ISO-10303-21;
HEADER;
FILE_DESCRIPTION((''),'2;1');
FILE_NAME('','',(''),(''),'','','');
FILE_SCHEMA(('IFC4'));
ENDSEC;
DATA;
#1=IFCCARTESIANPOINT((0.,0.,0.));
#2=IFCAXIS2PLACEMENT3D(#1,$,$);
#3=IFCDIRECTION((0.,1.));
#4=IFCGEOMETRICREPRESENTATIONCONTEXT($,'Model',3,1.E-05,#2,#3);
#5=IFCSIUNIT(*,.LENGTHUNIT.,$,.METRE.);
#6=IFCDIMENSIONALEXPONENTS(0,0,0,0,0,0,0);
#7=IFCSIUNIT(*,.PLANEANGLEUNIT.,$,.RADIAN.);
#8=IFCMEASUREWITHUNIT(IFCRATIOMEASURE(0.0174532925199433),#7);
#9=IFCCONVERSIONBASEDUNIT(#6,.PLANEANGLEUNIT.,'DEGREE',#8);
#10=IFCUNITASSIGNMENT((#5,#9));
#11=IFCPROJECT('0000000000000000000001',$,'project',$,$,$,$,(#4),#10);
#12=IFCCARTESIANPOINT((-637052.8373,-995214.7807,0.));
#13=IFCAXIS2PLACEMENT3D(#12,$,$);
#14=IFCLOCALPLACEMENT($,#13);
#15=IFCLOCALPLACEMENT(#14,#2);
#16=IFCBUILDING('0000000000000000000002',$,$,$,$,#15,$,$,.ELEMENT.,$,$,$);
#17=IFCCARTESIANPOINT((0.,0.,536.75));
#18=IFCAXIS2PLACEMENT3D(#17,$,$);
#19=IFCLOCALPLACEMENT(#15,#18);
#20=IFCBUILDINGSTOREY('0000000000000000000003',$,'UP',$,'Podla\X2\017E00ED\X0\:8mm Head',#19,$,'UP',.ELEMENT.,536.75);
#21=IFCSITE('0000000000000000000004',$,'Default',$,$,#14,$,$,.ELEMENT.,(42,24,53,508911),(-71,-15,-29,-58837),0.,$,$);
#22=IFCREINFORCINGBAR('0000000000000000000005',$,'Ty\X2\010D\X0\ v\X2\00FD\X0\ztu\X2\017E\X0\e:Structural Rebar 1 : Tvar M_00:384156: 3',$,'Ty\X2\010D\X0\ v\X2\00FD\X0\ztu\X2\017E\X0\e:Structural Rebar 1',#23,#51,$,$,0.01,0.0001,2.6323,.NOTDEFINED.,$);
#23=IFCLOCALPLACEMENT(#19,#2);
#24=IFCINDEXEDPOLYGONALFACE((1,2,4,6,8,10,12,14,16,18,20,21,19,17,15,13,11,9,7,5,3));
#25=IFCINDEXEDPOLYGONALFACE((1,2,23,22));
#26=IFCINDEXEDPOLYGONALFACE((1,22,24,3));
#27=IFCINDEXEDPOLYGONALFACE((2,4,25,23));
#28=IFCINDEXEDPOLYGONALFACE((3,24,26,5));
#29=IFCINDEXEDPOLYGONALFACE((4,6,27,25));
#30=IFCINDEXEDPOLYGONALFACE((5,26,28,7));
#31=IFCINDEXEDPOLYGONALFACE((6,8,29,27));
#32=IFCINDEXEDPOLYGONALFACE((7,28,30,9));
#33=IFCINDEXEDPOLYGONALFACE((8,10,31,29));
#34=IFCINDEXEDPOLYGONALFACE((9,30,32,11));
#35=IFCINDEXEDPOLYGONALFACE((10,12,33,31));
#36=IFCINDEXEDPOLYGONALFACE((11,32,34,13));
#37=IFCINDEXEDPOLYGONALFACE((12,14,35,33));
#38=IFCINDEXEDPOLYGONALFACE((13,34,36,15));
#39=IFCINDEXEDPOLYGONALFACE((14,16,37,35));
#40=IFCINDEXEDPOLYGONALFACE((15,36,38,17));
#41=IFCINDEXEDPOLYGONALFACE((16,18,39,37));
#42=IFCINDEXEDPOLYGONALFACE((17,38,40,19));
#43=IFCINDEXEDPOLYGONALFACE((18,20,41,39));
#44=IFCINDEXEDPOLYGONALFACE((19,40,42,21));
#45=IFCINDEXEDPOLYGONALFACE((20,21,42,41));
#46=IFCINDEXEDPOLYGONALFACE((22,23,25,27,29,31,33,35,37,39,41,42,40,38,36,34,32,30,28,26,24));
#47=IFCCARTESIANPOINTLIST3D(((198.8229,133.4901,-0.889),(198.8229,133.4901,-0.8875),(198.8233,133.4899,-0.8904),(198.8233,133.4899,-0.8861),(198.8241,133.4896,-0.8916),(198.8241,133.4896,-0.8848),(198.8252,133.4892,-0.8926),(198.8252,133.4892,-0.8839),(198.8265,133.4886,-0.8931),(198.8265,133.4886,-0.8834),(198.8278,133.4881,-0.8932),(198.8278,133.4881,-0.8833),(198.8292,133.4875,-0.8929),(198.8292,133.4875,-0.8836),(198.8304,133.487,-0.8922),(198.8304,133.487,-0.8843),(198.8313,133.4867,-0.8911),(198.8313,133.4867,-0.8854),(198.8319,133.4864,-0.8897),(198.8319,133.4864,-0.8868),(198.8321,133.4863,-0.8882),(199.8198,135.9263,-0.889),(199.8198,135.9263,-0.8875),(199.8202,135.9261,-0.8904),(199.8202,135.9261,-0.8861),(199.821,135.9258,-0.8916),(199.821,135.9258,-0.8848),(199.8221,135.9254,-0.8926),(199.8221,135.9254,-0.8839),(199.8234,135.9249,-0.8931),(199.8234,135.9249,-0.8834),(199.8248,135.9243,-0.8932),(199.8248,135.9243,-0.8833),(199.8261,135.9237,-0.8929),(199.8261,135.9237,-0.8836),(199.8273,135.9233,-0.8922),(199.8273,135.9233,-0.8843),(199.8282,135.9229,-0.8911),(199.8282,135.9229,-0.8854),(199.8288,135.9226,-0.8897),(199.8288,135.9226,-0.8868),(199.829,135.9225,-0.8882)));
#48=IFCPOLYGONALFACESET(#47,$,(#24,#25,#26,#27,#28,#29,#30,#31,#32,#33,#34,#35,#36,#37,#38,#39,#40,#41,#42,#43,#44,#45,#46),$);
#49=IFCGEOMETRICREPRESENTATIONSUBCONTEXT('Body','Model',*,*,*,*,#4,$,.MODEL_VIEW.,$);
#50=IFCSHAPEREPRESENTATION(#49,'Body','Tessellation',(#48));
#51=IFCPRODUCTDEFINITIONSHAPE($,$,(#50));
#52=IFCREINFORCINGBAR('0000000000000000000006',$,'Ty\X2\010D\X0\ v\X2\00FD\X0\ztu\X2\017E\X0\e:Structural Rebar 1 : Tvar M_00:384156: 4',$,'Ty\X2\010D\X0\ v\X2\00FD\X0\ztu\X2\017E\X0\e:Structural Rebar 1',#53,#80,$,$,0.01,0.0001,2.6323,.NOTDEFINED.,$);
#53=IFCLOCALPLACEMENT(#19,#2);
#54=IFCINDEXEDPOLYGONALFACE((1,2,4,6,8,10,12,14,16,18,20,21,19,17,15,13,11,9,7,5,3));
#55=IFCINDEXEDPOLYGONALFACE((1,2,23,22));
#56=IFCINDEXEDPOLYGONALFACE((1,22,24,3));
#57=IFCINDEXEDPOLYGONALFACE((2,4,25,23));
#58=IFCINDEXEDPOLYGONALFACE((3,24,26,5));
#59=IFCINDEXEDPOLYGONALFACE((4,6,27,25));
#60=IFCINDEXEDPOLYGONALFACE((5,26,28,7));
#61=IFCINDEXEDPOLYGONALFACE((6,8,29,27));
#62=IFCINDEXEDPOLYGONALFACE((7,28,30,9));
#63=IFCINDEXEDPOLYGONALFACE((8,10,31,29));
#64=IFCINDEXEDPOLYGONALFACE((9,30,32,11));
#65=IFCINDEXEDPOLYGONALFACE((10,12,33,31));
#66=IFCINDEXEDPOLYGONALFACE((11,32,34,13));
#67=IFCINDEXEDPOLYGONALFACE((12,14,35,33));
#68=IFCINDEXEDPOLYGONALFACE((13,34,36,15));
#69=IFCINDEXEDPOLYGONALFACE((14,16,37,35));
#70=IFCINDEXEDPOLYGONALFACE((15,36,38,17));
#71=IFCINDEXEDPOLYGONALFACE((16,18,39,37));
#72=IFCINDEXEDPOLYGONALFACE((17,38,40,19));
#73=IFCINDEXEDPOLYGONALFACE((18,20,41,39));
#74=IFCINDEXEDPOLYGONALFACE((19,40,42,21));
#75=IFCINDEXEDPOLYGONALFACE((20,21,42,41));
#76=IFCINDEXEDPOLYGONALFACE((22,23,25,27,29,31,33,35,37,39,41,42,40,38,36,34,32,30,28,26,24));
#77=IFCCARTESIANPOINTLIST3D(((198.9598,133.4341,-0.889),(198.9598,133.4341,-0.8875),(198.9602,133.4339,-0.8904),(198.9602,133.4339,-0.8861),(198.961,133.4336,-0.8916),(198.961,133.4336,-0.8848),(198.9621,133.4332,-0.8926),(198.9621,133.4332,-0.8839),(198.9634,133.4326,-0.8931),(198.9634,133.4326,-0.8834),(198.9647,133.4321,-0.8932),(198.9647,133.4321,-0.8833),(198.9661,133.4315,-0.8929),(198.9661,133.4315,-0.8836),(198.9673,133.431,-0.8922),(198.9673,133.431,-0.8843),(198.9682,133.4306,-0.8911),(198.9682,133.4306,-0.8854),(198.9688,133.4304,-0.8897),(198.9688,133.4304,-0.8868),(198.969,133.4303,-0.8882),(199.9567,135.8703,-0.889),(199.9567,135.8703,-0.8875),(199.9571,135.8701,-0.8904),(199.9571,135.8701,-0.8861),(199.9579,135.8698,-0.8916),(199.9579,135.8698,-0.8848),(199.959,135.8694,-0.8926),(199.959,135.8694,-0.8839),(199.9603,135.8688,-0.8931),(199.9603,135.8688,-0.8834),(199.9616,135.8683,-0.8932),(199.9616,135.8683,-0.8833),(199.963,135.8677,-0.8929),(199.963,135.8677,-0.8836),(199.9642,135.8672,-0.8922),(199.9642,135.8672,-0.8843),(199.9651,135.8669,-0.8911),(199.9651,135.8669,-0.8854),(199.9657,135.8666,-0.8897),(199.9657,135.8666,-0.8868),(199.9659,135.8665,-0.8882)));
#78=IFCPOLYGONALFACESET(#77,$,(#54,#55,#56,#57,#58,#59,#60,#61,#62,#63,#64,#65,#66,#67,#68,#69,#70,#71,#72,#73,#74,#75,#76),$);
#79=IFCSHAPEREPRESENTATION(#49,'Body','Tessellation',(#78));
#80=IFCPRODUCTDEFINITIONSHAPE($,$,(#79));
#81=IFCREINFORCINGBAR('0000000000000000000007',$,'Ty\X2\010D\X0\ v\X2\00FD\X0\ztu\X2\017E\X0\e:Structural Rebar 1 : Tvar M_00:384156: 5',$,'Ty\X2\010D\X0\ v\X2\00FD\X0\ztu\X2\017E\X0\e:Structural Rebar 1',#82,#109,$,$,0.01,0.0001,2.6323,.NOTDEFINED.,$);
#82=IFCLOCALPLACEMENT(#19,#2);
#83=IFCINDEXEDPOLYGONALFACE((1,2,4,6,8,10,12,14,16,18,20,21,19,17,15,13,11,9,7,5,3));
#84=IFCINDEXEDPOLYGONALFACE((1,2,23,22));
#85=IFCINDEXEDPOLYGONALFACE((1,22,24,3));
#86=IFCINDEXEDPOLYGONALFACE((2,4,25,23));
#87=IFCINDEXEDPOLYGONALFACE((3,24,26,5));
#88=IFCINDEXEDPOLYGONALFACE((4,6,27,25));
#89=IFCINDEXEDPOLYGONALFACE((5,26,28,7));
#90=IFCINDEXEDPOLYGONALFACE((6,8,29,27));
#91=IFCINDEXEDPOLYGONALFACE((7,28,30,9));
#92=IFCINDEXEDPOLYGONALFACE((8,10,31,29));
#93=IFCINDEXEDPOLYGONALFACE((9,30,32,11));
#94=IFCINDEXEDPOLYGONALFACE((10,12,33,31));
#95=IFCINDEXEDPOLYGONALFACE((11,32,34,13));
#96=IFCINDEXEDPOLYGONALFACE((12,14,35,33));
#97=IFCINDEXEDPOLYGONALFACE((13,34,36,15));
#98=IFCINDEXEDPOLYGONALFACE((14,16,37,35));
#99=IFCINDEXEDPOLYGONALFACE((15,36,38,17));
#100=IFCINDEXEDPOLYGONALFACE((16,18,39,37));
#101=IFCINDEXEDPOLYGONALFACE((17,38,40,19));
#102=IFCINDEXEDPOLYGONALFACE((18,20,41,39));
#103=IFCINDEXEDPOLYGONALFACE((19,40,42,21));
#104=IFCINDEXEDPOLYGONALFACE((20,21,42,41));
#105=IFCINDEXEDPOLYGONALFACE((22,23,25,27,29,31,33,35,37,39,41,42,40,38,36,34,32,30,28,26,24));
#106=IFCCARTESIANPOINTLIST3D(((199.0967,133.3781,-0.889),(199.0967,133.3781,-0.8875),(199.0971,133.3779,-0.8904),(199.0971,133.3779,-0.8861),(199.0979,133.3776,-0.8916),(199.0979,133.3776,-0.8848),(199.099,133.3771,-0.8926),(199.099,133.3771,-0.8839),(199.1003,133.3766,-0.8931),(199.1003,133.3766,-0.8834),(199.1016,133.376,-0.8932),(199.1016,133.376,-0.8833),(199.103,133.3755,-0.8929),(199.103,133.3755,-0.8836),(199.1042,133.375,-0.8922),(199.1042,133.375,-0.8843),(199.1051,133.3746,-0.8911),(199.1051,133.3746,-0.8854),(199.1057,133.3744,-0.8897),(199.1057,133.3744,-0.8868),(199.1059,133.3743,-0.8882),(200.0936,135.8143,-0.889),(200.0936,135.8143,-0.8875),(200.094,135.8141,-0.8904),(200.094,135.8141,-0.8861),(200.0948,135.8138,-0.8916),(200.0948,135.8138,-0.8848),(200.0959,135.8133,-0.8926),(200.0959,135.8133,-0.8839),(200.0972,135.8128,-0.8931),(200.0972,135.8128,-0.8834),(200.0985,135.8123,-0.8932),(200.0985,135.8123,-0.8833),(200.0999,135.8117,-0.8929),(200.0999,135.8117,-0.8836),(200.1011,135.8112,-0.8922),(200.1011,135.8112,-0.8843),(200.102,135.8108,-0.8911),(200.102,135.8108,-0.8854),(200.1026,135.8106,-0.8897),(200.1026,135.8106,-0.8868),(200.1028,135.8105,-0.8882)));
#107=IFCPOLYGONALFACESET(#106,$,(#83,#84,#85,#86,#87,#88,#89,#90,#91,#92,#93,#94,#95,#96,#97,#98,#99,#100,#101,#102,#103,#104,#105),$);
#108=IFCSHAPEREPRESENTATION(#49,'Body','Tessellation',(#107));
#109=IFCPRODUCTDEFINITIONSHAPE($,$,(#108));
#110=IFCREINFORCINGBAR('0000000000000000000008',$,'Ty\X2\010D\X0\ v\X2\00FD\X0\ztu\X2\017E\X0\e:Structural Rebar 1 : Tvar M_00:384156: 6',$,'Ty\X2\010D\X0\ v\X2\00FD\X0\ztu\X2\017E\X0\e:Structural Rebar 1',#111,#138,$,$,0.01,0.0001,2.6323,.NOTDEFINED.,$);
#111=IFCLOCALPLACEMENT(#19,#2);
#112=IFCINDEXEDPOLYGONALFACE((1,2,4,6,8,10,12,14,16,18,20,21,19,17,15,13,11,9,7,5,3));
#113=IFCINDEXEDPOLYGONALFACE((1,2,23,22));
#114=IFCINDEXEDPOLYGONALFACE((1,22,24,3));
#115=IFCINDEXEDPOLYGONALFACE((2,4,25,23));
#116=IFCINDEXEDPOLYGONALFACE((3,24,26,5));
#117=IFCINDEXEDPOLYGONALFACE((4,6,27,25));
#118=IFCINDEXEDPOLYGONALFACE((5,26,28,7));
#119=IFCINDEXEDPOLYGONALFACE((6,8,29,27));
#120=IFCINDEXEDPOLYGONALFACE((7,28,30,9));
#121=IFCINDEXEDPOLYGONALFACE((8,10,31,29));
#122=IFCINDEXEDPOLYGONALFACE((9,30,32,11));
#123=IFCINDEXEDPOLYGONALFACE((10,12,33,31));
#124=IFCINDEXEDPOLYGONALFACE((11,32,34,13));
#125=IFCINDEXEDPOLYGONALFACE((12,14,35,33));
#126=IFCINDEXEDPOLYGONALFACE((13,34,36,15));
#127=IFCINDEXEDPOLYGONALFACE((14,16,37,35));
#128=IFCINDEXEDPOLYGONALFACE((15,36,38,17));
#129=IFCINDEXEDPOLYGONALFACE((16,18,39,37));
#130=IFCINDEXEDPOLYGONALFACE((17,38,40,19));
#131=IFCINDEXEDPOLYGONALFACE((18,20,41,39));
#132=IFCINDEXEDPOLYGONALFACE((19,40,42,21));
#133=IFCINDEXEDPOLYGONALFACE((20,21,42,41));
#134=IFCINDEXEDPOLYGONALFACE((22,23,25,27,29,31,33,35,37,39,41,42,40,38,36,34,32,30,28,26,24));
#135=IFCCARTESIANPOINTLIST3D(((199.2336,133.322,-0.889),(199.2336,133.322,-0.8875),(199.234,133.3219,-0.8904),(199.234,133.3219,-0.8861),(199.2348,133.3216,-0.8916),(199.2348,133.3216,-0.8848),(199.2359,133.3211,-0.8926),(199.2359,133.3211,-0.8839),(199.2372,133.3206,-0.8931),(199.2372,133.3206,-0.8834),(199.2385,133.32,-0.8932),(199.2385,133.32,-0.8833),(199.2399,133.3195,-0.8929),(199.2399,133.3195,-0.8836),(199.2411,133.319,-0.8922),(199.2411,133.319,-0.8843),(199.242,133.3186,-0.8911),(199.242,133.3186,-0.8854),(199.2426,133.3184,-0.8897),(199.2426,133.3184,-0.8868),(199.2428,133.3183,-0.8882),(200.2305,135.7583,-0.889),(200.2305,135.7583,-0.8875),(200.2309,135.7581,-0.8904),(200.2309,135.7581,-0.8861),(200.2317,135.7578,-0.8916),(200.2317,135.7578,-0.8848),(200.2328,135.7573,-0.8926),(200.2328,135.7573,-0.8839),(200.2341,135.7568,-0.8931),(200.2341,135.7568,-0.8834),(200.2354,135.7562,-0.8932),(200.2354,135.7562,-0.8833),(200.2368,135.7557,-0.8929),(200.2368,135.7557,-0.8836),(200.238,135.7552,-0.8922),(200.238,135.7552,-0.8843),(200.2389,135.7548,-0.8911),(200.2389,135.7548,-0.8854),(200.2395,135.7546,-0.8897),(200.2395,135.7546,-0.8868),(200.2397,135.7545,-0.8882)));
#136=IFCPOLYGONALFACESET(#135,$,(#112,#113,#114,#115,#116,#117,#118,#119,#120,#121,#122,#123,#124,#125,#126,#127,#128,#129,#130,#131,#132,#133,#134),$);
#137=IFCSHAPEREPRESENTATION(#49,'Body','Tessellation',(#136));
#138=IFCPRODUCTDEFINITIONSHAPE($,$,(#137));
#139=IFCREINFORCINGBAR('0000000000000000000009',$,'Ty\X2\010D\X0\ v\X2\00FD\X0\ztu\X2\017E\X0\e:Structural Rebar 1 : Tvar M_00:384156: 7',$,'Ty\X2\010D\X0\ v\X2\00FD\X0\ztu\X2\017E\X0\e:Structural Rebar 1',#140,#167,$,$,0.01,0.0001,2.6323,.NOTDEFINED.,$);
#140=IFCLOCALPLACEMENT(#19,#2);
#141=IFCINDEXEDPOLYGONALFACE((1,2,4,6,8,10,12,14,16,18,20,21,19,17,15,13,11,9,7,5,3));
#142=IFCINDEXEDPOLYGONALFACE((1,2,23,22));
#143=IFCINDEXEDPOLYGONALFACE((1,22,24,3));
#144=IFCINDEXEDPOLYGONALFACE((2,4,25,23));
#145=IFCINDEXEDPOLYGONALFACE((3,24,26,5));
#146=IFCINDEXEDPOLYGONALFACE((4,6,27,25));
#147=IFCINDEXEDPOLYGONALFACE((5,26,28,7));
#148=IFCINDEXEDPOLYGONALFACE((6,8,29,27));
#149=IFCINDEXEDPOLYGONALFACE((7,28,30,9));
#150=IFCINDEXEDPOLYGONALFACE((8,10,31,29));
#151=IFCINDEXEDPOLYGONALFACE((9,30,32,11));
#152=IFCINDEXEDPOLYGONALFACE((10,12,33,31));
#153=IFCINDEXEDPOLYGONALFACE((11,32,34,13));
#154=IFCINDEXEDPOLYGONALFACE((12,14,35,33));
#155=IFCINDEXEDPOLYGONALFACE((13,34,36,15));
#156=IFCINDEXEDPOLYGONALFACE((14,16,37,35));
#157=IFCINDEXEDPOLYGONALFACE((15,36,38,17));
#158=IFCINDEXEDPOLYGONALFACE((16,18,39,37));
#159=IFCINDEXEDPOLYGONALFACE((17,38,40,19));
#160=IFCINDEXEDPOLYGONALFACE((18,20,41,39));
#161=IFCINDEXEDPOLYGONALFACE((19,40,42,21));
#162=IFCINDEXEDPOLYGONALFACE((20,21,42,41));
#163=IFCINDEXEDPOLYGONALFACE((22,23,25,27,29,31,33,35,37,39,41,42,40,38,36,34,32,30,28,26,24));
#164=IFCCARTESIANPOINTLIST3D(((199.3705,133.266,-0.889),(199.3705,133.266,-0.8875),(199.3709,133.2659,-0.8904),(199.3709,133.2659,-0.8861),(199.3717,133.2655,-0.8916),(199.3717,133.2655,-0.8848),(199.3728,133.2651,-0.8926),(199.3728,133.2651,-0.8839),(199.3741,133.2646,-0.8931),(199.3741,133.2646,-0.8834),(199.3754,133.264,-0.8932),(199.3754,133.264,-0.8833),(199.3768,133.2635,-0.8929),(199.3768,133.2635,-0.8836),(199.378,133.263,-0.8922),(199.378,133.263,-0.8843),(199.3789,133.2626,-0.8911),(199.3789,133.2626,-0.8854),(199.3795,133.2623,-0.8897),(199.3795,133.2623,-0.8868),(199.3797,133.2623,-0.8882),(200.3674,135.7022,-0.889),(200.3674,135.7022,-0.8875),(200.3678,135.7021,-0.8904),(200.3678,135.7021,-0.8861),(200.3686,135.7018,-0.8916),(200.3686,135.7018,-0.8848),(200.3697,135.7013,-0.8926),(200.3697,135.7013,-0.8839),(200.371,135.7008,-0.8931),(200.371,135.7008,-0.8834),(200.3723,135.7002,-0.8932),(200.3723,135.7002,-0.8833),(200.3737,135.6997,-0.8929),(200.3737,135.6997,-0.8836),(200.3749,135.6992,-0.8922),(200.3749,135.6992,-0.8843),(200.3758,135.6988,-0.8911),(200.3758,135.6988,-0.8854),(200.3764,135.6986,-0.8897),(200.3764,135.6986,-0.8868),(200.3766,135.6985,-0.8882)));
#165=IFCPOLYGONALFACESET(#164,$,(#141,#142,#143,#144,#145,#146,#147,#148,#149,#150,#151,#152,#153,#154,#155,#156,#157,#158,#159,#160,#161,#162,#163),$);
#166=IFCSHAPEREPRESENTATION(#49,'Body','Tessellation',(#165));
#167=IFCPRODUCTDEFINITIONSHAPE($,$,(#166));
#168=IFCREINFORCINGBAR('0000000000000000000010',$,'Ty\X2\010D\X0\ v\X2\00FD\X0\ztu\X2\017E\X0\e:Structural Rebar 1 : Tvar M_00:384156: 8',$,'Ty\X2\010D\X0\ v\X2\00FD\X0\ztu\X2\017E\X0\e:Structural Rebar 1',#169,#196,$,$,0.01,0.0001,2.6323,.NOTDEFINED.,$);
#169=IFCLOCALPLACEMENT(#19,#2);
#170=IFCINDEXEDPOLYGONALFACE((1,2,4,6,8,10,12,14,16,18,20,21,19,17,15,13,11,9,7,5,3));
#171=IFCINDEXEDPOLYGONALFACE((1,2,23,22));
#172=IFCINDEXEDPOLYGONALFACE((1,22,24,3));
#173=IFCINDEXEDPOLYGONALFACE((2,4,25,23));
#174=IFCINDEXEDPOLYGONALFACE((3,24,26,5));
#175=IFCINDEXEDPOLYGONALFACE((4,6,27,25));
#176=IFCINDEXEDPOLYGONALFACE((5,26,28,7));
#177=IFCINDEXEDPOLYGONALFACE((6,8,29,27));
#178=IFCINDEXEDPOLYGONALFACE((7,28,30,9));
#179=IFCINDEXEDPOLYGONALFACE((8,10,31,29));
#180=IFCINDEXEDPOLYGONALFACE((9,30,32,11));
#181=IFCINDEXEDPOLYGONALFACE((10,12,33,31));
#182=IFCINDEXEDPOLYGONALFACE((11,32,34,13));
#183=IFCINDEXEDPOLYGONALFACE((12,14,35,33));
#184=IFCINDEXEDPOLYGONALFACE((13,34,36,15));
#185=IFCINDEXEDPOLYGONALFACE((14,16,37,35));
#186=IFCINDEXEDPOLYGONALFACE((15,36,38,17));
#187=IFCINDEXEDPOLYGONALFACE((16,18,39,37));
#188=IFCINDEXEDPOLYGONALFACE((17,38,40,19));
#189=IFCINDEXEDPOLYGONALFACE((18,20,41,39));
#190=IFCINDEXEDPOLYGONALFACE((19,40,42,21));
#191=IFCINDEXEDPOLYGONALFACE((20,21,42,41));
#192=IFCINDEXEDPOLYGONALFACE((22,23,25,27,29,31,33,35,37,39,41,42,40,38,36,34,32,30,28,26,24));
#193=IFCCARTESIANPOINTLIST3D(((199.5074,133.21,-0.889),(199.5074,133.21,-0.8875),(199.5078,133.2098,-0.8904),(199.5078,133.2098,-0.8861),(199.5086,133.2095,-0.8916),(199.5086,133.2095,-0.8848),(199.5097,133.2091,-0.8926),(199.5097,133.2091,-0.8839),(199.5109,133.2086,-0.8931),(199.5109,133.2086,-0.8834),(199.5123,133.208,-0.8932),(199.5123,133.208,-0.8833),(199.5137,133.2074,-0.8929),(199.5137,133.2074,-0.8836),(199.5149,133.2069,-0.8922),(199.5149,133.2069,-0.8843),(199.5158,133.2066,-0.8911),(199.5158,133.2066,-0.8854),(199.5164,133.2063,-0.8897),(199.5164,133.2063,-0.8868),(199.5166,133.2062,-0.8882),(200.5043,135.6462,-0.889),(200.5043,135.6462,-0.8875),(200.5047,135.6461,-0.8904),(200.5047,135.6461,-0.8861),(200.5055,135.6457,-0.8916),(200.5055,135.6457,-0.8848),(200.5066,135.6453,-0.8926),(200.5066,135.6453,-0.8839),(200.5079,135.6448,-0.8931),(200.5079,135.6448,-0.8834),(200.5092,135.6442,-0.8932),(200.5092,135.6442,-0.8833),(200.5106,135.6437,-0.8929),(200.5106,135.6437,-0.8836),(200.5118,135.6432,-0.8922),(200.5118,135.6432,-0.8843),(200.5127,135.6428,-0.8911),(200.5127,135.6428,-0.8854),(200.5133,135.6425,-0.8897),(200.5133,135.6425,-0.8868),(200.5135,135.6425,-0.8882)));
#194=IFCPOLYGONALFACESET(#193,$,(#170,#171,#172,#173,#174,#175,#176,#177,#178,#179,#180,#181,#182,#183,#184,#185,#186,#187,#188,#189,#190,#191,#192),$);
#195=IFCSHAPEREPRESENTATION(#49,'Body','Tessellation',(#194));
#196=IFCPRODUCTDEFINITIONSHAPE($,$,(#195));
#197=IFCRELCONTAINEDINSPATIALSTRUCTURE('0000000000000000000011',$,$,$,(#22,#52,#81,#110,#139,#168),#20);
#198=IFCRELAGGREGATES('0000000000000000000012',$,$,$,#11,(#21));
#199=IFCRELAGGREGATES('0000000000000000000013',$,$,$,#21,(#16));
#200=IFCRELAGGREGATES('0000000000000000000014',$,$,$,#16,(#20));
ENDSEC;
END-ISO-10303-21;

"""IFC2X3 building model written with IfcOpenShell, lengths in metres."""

from ifc_helpers import new_model, entity, si_unit, converted_unit, direction, frame, origin, place, context, subcontext, project, spatial, element, save


model = new_model("IFC2X3")

# Units and contexts
model_context = context("Model", 3, precision=1e-05, world=origin(), true_north=direction((0.0, 1.0)))
body_context = subcontext(model_context, "Body", "Model", "MODEL_VIEW")
ifc_project = project(units=[si_unit("LENGTHUNIT", "METRE"), converted_unit("PLANEANGLEUNIT", "DEGREE", entity("IfcRatioMeasure", 0.0174532925199433), si_unit("PLANEANGLEUNIT", "RADIAN"), dimensions=[0, 0, 0, 0, 0, 0, 0])], contexts=[model_context])

# Site, building, storey
site_placement = place(None, frame((-637052.8373, -995214.7807, 0.0)))
site = spatial("IfcSite", under=ifc_project, at=site_placement, Name="Default", CompositionType="ELEMENT", RefLatitude=(42, 24, 53, 508911), RefLongitude=(-71, -15, -29, -58837), RefElevation=0.0)
building_placement = place(site_placement, origin())
building = spatial("IfcBuilding", under=site, at=building_placement, CompositionType="ELEMENT")
storey_placement = place(building_placement, frame((0.0, 0.0, 536.75)))
storey = spatial("IfcBuildingStorey", under=building, at=storey_placement, Name="UP", ObjectType="Podlaží:8mm Head", LongName="UP", CompositionType="ELEMENT", Elevation=536.75)

# Reinforcing bars
reinforcing_bar_1_placement = place(storey_placement, origin())
element("IfcReinforcingBar", 1, at=reinforcing_bar_1_placement, inside=storey, Name="Tyč výztuže:Structural Rebar 1 : Tvar M_00:384156: 3", ObjectType="Tyč výztuže:Structural Rebar 1", BarLength=2.6323, BarRole="NOTDEFINED", CrossSectionArea=0.0001, NominalDiameter=0.01, context=body_context, shape_type="AdvancedSweptSolid", body=[
    entity("IfcSweptDiskSolid", entity("IfcCompositeCurve", [entity("IfcCompositeCurveSegment", "CONTINUOUS", True, entity("IfcPolyline", [entity("IfcCartesianPoint", [-199.8244, -135.9244, 0.8882]), entity("IfcCartesianPoint", [-198.8275, -133.4882, 0.8882])]))], False), 0.005, None, 0.0, 1.0),
])
reinforcing_bar_2_placement = place(storey_placement, origin())
element("IfcReinforcingBar", 2, at=reinforcing_bar_2_placement, inside=storey, Name="Tyč výztuže:Structural Rebar 1 : Tvar M_00:384156: 4", ObjectType="Tyč výztuže:Structural Rebar 1", BarLength=2.6323, BarRole="NOTDEFINED", CrossSectionArea=0.0001, NominalDiameter=0.01, context=body_context, shape_type="AdvancedSweptSolid", body=[
    entity("IfcSweptDiskSolid", entity("IfcCompositeCurve", [entity("IfcCompositeCurveSegment", "CONTINUOUS", True, entity("IfcPolyline", [entity("IfcCartesianPoint", [-199.9613, -135.8684, 0.8882]), entity("IfcCartesianPoint", [-198.9644, -133.4322, 0.8882])]))], False), 0.005, None, 0.0, 1.0),
])
reinforcing_bar_3_placement = place(storey_placement, origin())
element("IfcReinforcingBar", 3, at=reinforcing_bar_3_placement, inside=storey, Name="Tyč výztuže:Structural Rebar 1 : Tvar M_00:384156: 5", ObjectType="Tyč výztuže:Structural Rebar 1", BarLength=2.6323, BarRole="NOTDEFINED", CrossSectionArea=0.0001, NominalDiameter=0.01, context=body_context, shape_type="AdvancedSweptSolid", body=[
    entity("IfcSweptDiskSolid", entity("IfcCompositeCurve", [entity("IfcCompositeCurveSegment", "CONTINUOUS", True, entity("IfcPolyline", [entity("IfcCartesianPoint", [-200.0982, -135.8124, 0.8882]), entity("IfcCartesianPoint", [-199.1013, -133.3762, 0.8882])]))], False), 0.005, None, 0.0, 1.0),
])
reinforcing_bar_4_placement = place(storey_placement, origin())
element("IfcReinforcingBar", 4, at=reinforcing_bar_4_placement, inside=storey, Name="Tyč výztuže:Structural Rebar 1 : Tvar M_00:384156: 6", ObjectType="Tyč výztuže:Structural Rebar 1", BarLength=2.6323, BarRole="NOTDEFINED", CrossSectionArea=0.0001, NominalDiameter=0.01, context=body_context, shape_type="AdvancedSweptSolid", body=[
    entity("IfcSweptDiskSolid", entity("IfcCompositeCurve", [entity("IfcCompositeCurveSegment", "CONTINUOUS", True, entity("IfcPolyline", [entity("IfcCartesianPoint", [-200.2351, -135.7564, 0.8882]), entity("IfcCartesianPoint", [-199.2382, -133.3202, 0.8882])]))], False), 0.005, None, 0.0, 1.0),
])
reinforcing_bar_5_placement = place(storey_placement, origin())
element("IfcReinforcingBar", 5, at=reinforcing_bar_5_placement, inside=storey, Name="Tyč výztuže:Structural Rebar 1 : Tvar M_00:384156: 7", ObjectType="Tyč výztuže:Structural Rebar 1", BarLength=2.6323, BarRole="NOTDEFINED", CrossSectionArea=0.0001, NominalDiameter=0.01, context=body_context, shape_type="AdvancedSweptSolid", body=[
    entity("IfcSweptDiskSolid", entity("IfcCompositeCurve", [entity("IfcCompositeCurveSegment", "CONTINUOUS", True, entity("IfcPolyline", [entity("IfcCartesianPoint", [-200.372, -135.7004, 0.8882]), entity("IfcCartesianPoint", [-199.3751, -133.2641, 0.8882])]))], False), 0.005, None, 0.0, 1.0),
])
reinforcing_bar_6_placement = place(storey_placement, origin())
element("IfcReinforcingBar", 6, at=reinforcing_bar_6_placement, inside=storey, Name="Tyč výztuže:Structural Rebar 1 : Tvar M_00:384156: 8", ObjectType="Tyč výztuže:Structural Rebar 1", BarLength=2.6323, BarRole="NOTDEFINED", CrossSectionArea=0.0001, NominalDiameter=0.01, context=body_context, shape_type="AdvancedSweptSolid", body=[
    entity("IfcSweptDiskSolid", entity("IfcCompositeCurve", [entity("IfcCompositeCurveSegment", "CONTINUOUS", True, entity("IfcPolyline", [entity("IfcCartesianPoint", [-200.5089, -135.6443, 0.8882]), entity("IfcCartesianPoint", [-199.512, -133.2081, 0.8882])]))], False), 0.005, None, 0.0, 1.0),
])

save(model, "model.ifc")
